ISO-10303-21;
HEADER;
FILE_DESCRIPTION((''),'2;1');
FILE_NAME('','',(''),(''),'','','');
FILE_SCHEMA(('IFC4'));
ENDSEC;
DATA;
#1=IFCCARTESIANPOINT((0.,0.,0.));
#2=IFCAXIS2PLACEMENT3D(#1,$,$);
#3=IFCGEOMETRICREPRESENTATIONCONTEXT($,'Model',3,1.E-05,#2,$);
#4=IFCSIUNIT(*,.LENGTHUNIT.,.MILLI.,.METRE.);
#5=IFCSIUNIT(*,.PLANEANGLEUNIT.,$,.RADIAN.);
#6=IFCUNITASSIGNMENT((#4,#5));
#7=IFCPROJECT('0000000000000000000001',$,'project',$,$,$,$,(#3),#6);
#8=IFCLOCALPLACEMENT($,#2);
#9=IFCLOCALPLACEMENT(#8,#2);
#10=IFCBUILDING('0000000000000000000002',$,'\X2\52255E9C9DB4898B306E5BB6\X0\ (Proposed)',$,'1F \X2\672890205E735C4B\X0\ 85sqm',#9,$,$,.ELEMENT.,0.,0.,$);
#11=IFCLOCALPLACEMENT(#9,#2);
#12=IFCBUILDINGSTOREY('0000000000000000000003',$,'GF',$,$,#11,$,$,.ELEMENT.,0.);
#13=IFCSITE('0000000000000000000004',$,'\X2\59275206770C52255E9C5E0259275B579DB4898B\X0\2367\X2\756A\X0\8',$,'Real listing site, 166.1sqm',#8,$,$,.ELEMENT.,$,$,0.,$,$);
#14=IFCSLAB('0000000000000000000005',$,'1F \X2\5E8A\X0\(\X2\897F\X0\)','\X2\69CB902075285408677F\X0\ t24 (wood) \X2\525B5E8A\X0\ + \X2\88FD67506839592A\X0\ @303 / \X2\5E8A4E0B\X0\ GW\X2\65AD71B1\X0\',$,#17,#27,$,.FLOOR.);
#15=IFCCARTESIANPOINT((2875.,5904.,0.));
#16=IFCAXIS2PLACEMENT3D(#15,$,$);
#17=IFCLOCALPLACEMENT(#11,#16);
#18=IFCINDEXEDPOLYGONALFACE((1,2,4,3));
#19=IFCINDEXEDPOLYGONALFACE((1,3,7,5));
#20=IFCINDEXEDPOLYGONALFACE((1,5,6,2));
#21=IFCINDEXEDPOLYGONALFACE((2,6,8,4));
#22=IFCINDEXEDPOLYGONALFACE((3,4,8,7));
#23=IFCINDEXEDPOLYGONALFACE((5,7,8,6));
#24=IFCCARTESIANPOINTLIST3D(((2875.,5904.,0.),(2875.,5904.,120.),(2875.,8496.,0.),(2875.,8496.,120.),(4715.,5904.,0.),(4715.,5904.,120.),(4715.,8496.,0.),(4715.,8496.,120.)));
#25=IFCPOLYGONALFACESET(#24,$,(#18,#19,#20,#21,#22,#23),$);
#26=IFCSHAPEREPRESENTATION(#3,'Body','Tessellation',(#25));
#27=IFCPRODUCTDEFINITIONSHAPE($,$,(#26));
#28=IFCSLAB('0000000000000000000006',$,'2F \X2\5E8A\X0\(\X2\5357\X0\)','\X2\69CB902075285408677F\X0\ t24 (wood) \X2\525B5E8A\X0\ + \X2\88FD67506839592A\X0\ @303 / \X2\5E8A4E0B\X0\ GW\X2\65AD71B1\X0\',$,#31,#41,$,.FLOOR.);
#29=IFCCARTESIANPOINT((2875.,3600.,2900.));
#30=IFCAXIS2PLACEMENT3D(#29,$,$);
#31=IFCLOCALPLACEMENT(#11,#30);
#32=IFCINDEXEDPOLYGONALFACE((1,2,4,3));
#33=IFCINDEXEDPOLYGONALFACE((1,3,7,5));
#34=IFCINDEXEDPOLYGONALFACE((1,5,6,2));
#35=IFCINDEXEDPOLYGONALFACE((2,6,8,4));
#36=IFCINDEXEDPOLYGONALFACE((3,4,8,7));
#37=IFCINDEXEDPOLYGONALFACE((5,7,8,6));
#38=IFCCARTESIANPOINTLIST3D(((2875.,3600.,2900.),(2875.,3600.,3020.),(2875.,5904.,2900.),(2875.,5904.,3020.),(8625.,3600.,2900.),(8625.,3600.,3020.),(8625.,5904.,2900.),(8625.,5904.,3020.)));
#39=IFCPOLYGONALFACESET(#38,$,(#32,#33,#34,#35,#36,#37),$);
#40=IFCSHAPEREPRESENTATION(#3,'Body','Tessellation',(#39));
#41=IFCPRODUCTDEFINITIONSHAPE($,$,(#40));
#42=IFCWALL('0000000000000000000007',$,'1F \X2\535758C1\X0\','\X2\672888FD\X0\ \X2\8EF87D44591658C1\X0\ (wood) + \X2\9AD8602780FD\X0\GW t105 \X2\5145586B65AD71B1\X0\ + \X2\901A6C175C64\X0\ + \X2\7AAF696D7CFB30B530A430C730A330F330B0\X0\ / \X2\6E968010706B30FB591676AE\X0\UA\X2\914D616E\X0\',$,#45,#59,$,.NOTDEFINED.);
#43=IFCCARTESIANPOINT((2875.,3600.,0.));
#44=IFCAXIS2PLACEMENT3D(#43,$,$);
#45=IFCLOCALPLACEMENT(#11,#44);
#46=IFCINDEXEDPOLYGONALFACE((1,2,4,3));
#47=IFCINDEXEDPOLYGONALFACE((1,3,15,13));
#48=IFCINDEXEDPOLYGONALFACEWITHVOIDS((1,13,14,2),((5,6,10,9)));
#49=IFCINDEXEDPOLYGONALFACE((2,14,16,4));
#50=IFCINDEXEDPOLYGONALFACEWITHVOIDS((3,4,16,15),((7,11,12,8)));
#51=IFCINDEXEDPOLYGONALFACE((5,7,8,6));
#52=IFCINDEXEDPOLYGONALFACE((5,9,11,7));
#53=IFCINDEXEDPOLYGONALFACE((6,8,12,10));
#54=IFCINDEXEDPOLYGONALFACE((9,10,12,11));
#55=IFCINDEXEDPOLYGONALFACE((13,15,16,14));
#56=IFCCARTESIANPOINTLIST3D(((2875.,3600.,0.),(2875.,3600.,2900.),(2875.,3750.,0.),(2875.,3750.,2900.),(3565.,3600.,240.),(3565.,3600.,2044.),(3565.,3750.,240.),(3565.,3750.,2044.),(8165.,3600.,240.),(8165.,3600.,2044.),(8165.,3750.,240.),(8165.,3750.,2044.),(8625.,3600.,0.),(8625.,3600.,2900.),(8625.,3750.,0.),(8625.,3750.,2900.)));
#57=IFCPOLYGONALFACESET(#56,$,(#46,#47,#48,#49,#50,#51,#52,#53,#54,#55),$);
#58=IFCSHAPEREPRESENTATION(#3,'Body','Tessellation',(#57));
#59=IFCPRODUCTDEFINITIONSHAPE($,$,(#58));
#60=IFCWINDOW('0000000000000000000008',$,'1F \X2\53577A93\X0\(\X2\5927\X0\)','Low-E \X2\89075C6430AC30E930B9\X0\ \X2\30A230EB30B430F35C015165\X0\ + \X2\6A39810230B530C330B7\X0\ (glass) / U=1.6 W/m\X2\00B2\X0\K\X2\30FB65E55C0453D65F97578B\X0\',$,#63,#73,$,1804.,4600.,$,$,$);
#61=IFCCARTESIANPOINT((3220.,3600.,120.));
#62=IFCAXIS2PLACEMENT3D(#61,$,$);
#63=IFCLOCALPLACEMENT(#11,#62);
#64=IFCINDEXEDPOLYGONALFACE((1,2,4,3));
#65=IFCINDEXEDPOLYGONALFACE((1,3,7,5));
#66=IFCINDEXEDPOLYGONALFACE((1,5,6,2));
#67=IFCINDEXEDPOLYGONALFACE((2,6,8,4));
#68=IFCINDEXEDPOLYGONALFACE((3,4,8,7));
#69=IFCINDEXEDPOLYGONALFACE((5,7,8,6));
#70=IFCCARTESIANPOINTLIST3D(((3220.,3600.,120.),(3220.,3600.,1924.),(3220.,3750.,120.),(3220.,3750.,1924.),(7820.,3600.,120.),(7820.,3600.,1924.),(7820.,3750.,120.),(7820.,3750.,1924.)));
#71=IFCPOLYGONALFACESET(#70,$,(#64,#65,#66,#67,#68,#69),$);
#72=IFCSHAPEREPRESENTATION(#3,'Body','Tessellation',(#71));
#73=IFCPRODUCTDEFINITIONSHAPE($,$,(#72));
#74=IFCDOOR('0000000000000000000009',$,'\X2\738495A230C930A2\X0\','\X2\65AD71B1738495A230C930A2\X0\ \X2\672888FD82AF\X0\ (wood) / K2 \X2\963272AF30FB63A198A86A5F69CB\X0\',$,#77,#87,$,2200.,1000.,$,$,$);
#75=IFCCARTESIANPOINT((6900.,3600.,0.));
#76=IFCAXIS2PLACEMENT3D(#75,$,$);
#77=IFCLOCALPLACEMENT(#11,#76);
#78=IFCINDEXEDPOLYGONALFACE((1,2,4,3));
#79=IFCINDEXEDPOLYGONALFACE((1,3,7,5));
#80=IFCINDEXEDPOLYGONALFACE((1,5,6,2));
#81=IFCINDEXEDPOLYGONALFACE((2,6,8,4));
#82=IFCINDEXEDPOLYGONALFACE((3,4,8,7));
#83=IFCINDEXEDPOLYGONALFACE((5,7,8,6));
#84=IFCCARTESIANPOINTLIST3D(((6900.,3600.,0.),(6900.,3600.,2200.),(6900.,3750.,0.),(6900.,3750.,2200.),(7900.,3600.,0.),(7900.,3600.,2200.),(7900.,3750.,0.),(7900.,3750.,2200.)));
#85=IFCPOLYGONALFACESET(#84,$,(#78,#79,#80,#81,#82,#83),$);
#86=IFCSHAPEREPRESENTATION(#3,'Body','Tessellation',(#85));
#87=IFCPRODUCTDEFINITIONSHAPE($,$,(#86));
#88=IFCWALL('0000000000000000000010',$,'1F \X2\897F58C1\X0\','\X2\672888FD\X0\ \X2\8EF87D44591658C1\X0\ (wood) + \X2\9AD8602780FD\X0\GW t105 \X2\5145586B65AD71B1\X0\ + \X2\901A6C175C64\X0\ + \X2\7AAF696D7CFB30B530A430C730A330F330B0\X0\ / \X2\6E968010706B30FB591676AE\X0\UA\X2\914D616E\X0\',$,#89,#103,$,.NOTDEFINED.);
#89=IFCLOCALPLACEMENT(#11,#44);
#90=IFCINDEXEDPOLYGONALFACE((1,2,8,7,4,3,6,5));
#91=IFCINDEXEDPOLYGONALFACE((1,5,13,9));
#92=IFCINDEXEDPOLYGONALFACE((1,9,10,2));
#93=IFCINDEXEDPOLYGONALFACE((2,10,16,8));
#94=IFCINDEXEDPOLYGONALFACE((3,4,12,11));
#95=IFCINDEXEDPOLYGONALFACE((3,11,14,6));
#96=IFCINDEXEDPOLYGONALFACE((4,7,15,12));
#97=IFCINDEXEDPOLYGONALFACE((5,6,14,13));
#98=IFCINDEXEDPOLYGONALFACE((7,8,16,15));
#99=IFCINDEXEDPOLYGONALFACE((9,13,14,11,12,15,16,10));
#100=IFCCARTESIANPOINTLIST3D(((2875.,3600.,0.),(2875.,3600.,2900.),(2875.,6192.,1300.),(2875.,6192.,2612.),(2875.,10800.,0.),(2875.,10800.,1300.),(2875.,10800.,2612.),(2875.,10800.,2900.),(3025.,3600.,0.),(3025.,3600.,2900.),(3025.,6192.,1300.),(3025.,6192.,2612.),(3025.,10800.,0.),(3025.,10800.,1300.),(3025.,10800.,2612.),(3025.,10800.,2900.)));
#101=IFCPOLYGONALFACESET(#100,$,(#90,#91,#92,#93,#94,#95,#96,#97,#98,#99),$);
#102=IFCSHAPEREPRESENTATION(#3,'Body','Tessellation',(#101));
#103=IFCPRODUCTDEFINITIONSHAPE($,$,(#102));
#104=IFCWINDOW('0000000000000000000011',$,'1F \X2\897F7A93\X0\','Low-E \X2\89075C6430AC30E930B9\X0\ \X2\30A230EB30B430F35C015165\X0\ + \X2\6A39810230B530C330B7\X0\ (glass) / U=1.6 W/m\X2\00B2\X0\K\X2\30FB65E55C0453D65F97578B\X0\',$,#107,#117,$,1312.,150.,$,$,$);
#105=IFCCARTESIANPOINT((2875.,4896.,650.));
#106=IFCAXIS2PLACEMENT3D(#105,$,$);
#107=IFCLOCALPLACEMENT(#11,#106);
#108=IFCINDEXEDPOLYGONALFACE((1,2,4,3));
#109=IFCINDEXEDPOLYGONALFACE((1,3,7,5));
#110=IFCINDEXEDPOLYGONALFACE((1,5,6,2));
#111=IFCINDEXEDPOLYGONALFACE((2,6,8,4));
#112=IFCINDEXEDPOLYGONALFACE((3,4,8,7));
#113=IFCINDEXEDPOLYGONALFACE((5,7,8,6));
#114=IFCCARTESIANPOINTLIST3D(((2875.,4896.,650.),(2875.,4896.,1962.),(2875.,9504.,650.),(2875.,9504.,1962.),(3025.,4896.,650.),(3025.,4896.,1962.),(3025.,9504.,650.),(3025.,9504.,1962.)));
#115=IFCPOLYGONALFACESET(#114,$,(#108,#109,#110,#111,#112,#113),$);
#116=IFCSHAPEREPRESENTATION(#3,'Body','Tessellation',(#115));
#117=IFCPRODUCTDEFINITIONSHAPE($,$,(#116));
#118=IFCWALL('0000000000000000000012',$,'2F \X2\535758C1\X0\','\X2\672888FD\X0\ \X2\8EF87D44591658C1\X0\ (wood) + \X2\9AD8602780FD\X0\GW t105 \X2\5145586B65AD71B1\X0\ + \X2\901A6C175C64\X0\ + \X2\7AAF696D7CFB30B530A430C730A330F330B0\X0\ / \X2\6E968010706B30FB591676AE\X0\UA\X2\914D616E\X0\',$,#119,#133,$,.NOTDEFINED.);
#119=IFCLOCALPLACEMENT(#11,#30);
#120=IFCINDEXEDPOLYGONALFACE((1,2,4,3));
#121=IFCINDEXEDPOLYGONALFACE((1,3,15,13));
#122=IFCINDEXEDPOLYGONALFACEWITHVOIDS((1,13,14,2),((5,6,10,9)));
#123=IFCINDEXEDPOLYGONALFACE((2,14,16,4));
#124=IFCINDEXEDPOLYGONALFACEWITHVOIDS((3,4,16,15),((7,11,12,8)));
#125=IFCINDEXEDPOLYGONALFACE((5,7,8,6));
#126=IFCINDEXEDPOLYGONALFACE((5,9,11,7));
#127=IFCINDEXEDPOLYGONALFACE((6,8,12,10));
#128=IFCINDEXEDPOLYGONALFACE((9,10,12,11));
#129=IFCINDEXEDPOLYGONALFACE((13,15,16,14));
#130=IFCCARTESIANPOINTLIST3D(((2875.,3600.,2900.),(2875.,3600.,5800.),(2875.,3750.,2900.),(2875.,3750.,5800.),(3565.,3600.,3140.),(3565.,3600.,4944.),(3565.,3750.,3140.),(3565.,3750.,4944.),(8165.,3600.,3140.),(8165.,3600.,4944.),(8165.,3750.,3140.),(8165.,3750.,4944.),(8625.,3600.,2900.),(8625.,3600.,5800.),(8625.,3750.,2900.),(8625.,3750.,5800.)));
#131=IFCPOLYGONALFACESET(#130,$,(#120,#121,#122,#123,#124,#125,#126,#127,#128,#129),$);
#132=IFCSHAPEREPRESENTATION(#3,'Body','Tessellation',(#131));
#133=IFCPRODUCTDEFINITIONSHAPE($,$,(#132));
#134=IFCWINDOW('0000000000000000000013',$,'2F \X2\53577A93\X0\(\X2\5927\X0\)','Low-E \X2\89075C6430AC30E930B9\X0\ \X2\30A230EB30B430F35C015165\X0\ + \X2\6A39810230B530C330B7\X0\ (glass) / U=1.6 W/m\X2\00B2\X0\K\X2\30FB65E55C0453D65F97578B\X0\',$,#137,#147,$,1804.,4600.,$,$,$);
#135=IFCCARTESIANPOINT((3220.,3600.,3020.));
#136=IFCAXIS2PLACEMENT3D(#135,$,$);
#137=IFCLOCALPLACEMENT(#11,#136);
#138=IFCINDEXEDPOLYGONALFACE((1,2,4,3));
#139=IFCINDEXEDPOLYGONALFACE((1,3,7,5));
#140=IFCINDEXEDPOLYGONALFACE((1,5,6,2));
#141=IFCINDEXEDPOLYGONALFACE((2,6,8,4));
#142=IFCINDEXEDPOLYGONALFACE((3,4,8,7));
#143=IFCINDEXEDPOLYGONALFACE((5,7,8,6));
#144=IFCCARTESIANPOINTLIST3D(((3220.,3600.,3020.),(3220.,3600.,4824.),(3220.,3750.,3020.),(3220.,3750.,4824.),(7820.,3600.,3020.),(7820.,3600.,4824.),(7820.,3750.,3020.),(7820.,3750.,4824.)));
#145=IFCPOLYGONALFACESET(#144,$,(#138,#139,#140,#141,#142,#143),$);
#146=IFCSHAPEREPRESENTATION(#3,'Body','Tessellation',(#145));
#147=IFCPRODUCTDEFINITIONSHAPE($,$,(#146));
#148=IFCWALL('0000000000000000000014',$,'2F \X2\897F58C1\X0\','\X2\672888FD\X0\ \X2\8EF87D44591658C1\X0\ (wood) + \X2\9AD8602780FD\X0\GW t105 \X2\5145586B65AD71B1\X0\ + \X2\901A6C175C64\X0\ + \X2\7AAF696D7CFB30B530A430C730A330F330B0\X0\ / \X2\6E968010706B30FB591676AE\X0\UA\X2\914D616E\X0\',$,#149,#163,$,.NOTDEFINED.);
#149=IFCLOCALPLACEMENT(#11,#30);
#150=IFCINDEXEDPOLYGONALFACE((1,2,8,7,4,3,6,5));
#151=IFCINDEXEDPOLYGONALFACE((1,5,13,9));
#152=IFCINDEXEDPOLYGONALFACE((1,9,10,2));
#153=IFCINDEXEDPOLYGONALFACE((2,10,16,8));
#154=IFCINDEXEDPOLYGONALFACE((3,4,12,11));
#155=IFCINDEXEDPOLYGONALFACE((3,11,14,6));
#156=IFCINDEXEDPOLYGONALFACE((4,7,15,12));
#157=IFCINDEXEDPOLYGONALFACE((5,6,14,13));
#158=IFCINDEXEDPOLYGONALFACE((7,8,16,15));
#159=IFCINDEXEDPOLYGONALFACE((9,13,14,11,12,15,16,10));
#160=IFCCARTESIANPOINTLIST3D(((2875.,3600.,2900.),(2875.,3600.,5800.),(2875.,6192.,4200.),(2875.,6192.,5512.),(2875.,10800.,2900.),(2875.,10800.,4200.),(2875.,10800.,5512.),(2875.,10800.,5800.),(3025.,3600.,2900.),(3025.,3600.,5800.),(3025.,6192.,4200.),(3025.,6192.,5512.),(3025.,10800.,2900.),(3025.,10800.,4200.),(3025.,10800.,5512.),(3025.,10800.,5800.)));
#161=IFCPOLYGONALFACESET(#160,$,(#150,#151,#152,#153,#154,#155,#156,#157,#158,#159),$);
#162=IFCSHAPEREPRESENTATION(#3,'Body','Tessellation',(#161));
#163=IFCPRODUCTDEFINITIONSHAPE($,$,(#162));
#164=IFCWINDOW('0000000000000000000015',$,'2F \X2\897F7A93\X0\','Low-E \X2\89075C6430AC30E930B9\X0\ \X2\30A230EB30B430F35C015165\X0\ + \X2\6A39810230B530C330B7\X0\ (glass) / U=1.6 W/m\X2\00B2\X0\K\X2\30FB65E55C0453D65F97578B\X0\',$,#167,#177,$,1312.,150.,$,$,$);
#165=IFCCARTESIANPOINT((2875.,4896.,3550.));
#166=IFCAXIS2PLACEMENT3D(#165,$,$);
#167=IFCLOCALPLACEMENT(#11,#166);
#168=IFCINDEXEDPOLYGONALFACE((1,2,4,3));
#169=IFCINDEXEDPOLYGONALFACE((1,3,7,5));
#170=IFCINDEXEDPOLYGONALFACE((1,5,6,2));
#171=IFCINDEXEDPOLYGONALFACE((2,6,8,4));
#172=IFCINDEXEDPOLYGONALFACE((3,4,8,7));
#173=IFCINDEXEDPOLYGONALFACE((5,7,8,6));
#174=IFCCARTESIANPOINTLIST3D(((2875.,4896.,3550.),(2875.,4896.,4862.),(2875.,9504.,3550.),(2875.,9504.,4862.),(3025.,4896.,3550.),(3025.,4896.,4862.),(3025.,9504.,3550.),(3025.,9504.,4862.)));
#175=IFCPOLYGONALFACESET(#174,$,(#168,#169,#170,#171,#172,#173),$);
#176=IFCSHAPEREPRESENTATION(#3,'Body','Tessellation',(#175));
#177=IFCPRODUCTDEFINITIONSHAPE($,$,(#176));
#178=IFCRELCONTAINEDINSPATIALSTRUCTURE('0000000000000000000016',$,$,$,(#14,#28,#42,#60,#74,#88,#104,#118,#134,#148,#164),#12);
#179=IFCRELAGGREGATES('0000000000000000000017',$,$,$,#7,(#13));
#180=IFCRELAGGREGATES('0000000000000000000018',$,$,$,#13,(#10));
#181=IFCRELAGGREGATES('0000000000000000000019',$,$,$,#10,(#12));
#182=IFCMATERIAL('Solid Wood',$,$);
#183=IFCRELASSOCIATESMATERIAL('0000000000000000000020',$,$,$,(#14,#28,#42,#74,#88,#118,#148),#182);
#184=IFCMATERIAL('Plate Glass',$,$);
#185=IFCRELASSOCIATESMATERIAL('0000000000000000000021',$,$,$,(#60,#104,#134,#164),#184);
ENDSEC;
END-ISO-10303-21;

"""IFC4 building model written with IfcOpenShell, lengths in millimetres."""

from ifc_helpers import new_model, si_unit, frame, frame_2d, origin, place, context, project, spatial, rectangle, extrude, material, element, fill, save


model = new_model("IFC4")

# Units and contexts
model_context = context("Model", 3, precision=1e-05, world=origin())
ifc_project = project(units=[si_unit("LENGTHUNIT", "METRE", prefix="MILLI"), si_unit("PLANEANGLEUNIT", "RADIAN")], contexts=[model_context])

# Site, building, storey
site_placement = place(None, origin())
site = spatial("IfcSite", under=ifc_project, at=site_placement, Name="大分県別府市大字鶴見2367番8", ObjectType="Real listing site, 166.1sqm", CompositionType="ELEMENT", RefElevation=0.0)
building_placement = place(site_placement, origin())
building = spatial("IfcBuilding", under=site, at=building_placement, Name="別府鶴見の家 (Proposed)", ObjectType="1F 木造平屋 85sqm", CompositionType="ELEMENT", ElevationOfRefHeight=0.0, ElevationOfTerrain=0.0)
storey_placement = place(building_placement, origin())
storey = spatial("IfcBuildingStorey", under=building, at=storey_placement, Name="GF", CompositionType="ELEMENT", Elevation=0.0)

# Slabs
ifc_material_1 = material(Name="Solid Wood")
slab_1_placement = place(storey_placement, frame((2875.0, 5904.0, 0.0)))
element("IfcSlab", 1, at=slab_1_placement, inside=storey, material=ifc_material_1, Name="1F 床(西)", Description="構造用合板 t24 (wood) 剛床 + 製材根太 @303 / 床下 GW断熱", PredefinedType="FLOOR", context=model_context, shape_type="SweptSolid", body=[
    extrude(rectangle(XDim=1840.0, YDim=2592.0, at=frame_2d((920.0, 1296.0))), frame((2875.0, 5904.0, 0.0)), (0.0, 0.0, 1.0), 120.0),
])
slab_2_placement = place(storey_placement, frame((2875.0, 3600.0, 2900.0)))
element("IfcSlab", 2, at=slab_2_placement, inside=storey, material=ifc_material_1, Name="2F 床(南)", Description="構造用合板 t24 (wood) 剛床 + 製材根太 @303 / 床下 GW断熱", PredefinedType="FLOOR", context=model_context, shape_type="SweptSolid", body=[
    extrude(rectangle(XDim=5750.0, YDim=2304.0, at=frame_2d((2875.0, 1152.0))), frame((2875.0, 3600.0, 2900.0)), (0.0, 0.0, 1.0), 120.0),
])

# Wall, openings, window, door
wall_1_placement = place(storey_placement, frame((2875.0, 3600.0, 0.0)))
wall_1 = element("IfcWall", 3, at=wall_1_placement, inside=storey, material=ifc_material_1, Name="1F 南壁", Description="木製 軸組外壁 (wood) + 高性能GW t105 充填断熱 + 通気層 + 窯業系サイディング / 準耐火・外皮UA配慮", PredefinedType="NOTDEFINED", context=model_context, shape_type="SweptSolid", body=[
    extrude(rectangle(XDim=5750.0, YDim=150.0, at=frame_2d((2875.0, 75.0))), frame((2875.0, 3600.0, 0.0)), (0.0, 0.0, 1.0), 2900.0),
])
opening_1_placement = place(storey_placement, frame((3220.0, 3600.0, 120.0)))
opening_1 = element("IfcOpeningElement", 4, at=opening_1_placement, cuts=wall_1, PredefinedType="NOTDEFINED", context=model_context, shape_type="SweptSolid", body=[
    extrude(rectangle(XDim=4600.0, YDim=150.0, at=frame_2d((2300.0, 75.0))), frame((3220.0, 3600.0, 120.0)), (0.0, 0.0, 1.0), 1804.0),
])
opening_2_placement = place(storey_placement, frame((6900.0, 3600.0, 0.0)))
opening_2 = element("IfcOpeningElement", 5, at=opening_2_placement, cuts=wall_1, PredefinedType="NOTDEFINED", context=model_context, shape_type="SweptSolid", body=[
    extrude(rectangle(XDim=1000.0, YDim=150.0, at=frame_2d((500.0, 75.0))), frame((6900.0, 3600.0, 0.0)), (0.0, 0.0, 1.0), 2200.0),
])
ifc_material_2 = material(Name="Plate Glass")
window_1_placement = place(storey_placement, frame((3220.0, 3600.0, 120.0)))
window_1 = element("IfcWindow", 6, at=window_1_placement, inside=storey, material=ifc_material_2, Name="1F 南窓(大)", Description="Low-E 複層ガラス アルゴン封入 + 樹脂サッシ (glass) / U=1.6 W/m²K・日射取得型", OverallHeight=1804.0, OverallWidth=4600.0, context=model_context, shape_type="SweptSolid", body=[
    extrude(rectangle(XDim=4600.0, YDim=150.0, at=frame_2d((2300.0, 75.0))), frame((3220.0, 3600.0, 120.0)), (0.0, 0.0, 1.0), 1804.0),
])
fill(opening_1, window_1)
door_placement = place(storey_placement, frame((6900.0, 3600.0, 0.0)))
door = element("IfcDoor", 7, at=door_placement, inside=storey, material=ifc_material_1, Name="玄関ドア", Description="断熱玄関ドア 木製芯 (wood) / K2 防犯・採風機構", OverallHeight=2200.0, OverallWidth=1000.0, context=model_context, shape_type="SweptSolid", body=[
    extrude(rectangle(XDim=1000.0, YDim=150.0, at=frame_2d((500.0, 75.0))), frame((6900.0, 3600.0, 0.0)), (0.0, 0.0, 1.0), 2200.0),
])
fill(opening_2, door)

# Walls, openings, windows
wall_2_placement = place(storey_placement, frame((2875.0, 3600.0, 0.0)))
wall_2 = element("IfcWall", 8, at=wall_2_placement, inside=storey, material=ifc_material_1, Name="1F 西壁", Description="木製 軸組外壁 (wood) + 高性能GW t105 充填断熱 + 通気層 + 窯業系サイディング / 準耐火・外皮UA配慮", PredefinedType="NOTDEFINED", context=model_context, shape_type="SweptSolid", body=[
    extrude(rectangle(XDim=150.0, YDim=7200.0, at=frame_2d((75.0, 3600.0))), frame((2875.0, 3600.0, 0.0)), (0.0, 0.0, 1.0), 2900.0),
])
opening_3_placement = place(storey_placement, frame((2875.0, 4896.0, 650.0)))
opening_3 = element("IfcOpeningElement", 9, at=opening_3_placement, cuts=wall_2, PredefinedType="NOTDEFINED", context=model_context, shape_type="SweptSolid", body=[
    extrude(rectangle(XDim=150.0, YDim=4608.0, at=frame_2d((75.0, 2304.0))), frame((2875.0, 4896.0, 650.0)), (0.0, 0.0, 1.0), 1312.0),
])
window_2_placement = place(storey_placement, frame((2875.0, 4896.0, 650.0)))
window_2 = element("IfcWindow", 10, at=window_2_placement, inside=storey, material=ifc_material_2, Name="1F 西窓", Description="Low-E 複層ガラス アルゴン封入 + 樹脂サッシ (glass) / U=1.6 W/m²K・日射取得型", OverallHeight=1312.0, OverallWidth=150.0, context=model_context, shape_type="SweptSolid", body=[
    extrude(rectangle(XDim=150.0, YDim=4608.0, at=frame_2d((75.0, 2304.0))), frame((2875.0, 4896.0, 650.0)), (0.0, 0.0, 1.0), 1312.0),
])
fill(opening_3, window_2)
wall_3_placement = place(storey_placement, frame((2875.0, 3600.0, 2900.0)))
wall_3 = element("IfcWall", 11, at=wall_3_placement, inside=storey, material=ifc_material_1, Name="2F 南壁", Description="木製 軸組外壁 (wood) + 高性能GW t105 充填断熱 + 通気層 + 窯業系サイディング / 準耐火・外皮UA配慮", PredefinedType="NOTDEFINED", context=model_context, shape_type="SweptSolid", body=[
    extrude(rectangle(XDim=5750.0, YDim=150.0, at=frame_2d((2875.0, 75.0))), frame((2875.0, 3600.0, 2900.0)), (0.0, 0.0, 1.0), 2900.0),
])
opening_4_placement = place(storey_placement, frame((3220.0, 3600.0, 3020.0)))
opening_4 = element("IfcOpeningElement", 12, at=opening_4_placement, cuts=wall_3, PredefinedType="NOTDEFINED", context=model_context, shape_type="SweptSolid", body=[
    extrude(rectangle(XDim=4600.0, YDim=150.0, at=frame_2d((2300.0, 75.0))), frame((3220.0, 3600.0, 3020.0)), (0.0, 0.0, 1.0), 1804.0),
])
window_3_placement = place(storey_placement, frame((3220.0, 3600.0, 3020.0)))
window_3 = element("IfcWindow", 13, at=window_3_placement, inside=storey, material=ifc_material_2, Name="2F 南窓(大)", Description="Low-E 複層ガラス アルゴン封入 + 樹脂サッシ (glass) / U=1.6 W/m²K・日射取得型", OverallHeight=1804.0, OverallWidth=4600.0, context=model_context, shape_type="SweptSolid", body=[
    extrude(rectangle(XDim=4600.0, YDim=150.0, at=frame_2d((2300.0, 75.0))), frame((3220.0, 3600.0, 3020.0)), (0.0, 0.0, 1.0), 1804.0),
])
fill(opening_4, window_3)
wall_4_placement = place(storey_placement, frame((2875.0, 3600.0, 2900.0)))
wall_4 = element("IfcWall", 14, at=wall_4_placement, inside=storey, material=ifc_material_1, Name="2F 西壁", Description="木製 軸組外壁 (wood) + 高性能GW t105 充填断熱 + 通気層 + 窯業系サイディング / 準耐火・外皮UA配慮", PredefinedType="NOTDEFINED", context=model_context, shape_type="SweptSolid", body=[
    extrude(rectangle(XDim=150.0, YDim=7200.0, at=frame_2d((75.0, 3600.0))), frame((2875.0, 3600.0, 2900.0)), (0.0, 0.0, 1.0), 2900.0),
])
opening_5_placement = place(storey_placement, frame((2875.0, 4896.0, 3550.0)))
opening_5 = element("IfcOpeningElement", 15, at=opening_5_placement, cuts=wall_4, PredefinedType="NOTDEFINED", context=model_context, shape_type="SweptSolid", body=[
    extrude(rectangle(XDim=150.0, YDim=4608.0, at=frame_2d((75.0, 2304.0))), frame((2875.0, 4896.0, 3550.0)), (0.0, 0.0, 1.0), 1312.0),
])
window_4_placement = place(storey_placement, frame((2875.0, 4896.0, 3550.0)))
window_4 = element("IfcWindow", 16, at=window_4_placement, inside=storey, material=ifc_material_2, Name="2F 西窓", Description="Low-E 複層ガラス アルゴン封入 + 樹脂サッシ (glass) / U=1.6 W/m²K・日射取得型", OverallHeight=1312.0, OverallWidth=150.0, context=model_context, shape_type="SweptSolid", body=[
    extrude(rectangle(XDim=150.0, YDim=4608.0, at=frame_2d((75.0, 2304.0))), frame((2875.0, 4896.0, 3550.0)), (0.0, 0.0, 1.0), 1312.0),
])
fill(opening_5, window_4)

save(model, "model.ifc")
